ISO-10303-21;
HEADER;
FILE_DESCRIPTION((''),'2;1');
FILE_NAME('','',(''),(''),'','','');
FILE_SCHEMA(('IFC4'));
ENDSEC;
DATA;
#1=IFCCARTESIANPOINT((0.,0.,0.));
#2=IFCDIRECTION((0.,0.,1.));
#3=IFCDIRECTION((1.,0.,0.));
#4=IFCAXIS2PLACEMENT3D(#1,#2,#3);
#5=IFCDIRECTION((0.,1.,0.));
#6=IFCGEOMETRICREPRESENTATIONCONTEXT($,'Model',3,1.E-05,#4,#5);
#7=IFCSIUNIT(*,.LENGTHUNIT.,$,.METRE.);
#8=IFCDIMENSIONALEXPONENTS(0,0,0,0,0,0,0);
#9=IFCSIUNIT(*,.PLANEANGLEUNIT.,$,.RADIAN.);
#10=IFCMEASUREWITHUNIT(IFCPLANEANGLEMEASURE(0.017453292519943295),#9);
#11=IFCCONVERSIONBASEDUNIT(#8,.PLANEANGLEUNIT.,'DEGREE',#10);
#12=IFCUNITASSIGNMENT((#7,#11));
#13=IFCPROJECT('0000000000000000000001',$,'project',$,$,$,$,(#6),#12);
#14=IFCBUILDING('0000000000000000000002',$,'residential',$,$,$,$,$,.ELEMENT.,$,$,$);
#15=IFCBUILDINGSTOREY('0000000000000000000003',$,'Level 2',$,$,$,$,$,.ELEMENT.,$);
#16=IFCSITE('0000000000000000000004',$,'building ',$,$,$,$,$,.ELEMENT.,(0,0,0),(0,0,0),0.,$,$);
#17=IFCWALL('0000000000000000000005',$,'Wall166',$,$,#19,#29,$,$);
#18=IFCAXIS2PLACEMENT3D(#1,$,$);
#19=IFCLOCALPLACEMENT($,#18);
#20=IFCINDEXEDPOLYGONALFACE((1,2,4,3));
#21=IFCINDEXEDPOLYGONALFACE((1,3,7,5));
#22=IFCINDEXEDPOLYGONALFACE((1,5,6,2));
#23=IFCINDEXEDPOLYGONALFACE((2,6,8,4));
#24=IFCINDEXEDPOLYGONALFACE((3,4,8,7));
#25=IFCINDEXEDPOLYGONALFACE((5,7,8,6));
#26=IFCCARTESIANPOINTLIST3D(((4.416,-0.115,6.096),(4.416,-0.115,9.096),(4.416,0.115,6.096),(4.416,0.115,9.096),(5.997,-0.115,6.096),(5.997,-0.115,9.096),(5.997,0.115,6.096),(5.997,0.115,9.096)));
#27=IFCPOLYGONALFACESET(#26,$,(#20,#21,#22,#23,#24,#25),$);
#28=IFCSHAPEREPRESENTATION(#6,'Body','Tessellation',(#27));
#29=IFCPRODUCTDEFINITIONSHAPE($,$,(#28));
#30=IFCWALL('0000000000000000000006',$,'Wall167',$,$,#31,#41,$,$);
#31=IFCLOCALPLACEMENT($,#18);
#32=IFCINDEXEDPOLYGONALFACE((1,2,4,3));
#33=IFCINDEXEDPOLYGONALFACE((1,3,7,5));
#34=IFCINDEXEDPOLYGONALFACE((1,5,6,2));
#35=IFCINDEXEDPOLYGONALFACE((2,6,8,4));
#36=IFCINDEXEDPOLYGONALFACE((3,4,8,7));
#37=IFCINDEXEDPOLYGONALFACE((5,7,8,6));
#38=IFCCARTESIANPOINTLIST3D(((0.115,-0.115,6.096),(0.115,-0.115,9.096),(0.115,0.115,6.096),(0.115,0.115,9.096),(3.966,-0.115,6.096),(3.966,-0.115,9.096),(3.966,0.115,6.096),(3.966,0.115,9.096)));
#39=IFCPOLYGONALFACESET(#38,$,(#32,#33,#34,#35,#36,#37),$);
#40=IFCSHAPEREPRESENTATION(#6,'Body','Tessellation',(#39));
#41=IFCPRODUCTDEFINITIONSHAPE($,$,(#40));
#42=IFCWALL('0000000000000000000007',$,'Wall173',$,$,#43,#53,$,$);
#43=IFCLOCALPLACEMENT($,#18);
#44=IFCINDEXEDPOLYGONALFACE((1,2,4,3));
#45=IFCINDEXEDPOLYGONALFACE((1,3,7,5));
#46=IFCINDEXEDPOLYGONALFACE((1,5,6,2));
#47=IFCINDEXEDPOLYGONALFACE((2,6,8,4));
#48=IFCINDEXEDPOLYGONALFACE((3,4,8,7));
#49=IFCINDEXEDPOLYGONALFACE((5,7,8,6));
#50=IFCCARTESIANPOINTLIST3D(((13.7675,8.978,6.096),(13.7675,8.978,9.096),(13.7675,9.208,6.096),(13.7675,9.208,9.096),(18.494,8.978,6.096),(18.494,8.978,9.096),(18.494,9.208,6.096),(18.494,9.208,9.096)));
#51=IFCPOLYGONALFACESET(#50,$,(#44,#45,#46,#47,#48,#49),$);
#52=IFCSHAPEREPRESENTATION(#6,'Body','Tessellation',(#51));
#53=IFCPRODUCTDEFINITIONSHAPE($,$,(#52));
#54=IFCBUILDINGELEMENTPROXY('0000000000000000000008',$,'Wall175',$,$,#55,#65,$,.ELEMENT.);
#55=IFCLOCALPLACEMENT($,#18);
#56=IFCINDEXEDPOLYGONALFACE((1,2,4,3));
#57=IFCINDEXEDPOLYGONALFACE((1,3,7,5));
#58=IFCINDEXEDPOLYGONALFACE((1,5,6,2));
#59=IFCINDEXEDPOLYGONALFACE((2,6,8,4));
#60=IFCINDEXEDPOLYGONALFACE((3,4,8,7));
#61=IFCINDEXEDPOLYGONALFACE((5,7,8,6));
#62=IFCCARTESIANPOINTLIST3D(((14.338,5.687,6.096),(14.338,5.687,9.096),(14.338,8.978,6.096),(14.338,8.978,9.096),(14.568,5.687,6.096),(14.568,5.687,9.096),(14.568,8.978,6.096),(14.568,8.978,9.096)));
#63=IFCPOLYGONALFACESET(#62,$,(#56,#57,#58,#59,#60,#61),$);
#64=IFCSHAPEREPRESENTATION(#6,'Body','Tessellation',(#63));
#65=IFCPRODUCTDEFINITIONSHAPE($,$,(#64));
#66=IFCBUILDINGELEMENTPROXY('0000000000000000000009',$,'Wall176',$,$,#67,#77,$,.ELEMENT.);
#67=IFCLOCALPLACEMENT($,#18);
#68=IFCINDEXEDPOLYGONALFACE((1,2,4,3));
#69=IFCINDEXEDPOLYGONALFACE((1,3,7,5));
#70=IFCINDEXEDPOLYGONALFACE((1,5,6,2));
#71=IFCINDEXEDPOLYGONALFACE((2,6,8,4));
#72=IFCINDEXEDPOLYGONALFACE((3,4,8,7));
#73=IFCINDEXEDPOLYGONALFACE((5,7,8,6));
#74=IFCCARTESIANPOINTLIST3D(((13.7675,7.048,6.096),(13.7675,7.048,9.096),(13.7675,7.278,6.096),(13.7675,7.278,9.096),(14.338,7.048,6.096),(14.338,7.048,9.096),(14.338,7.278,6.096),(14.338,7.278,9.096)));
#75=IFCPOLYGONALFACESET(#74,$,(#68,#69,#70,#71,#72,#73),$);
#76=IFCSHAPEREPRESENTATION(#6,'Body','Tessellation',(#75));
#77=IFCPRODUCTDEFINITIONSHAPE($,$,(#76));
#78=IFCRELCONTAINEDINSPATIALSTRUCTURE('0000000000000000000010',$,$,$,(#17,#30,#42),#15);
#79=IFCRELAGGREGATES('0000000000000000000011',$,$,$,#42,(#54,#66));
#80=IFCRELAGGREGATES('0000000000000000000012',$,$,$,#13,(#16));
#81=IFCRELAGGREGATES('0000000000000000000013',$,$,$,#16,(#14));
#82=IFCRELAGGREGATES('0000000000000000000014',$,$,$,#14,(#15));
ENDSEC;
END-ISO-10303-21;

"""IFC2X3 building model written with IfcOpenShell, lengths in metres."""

from ifc_helpers import new_model, entity, si_unit, converted_unit, direction, frame, frame_2d, origin_with_axes, place, context, project, spatial, rectangle, extrude, element, aggregate, save


model = new_model("IFC2X3")

# Units and contexts
model_context = context("Model", 3, precision=1e-05, world=origin_with_axes(), true_north=direction((0.0, 1.0, 0.0)))
ifc_project = project(units=[si_unit("LENGTHUNIT", "METRE"), converted_unit("PLANEANGLEUNIT", "DEGREE", entity("IfcPlaneAngleMeasure", 0.017453292519943295), si_unit("PLANEANGLEUNIT", "RADIAN"), dimensions=[0, 0, 0, 0, 0, 0, 0])], contexts=[model_context])

# Site, building, storey
site = spatial("IfcSite", under=ifc_project, Name="building ", CompositionType="ELEMENT", RefLatitude=(0, 0, 0), RefLongitude=(0, 0, 0), RefElevation=0.0)
building = spatial("IfcBuilding", under=site, Name="residential", CompositionType="ELEMENT")
storey = spatial("IfcBuildingStorey", under=building, Name="Level 2", CompositionType="ELEMENT")

# Shared definitions
placement = place(None, origin_with_axes())

# Walls
element("IfcWall", 1, at=placement, inside=storey, Name="Wall166", context=model_context, shape_type="SweptSolid", body=[
    extrude(rectangle(XDim=1.581, YDim=0.23, at=frame_2d((0.0, 0.0), x_axis=(1.0, 0.0, 0.0))), frame((5.2065, 0.0, 6.096), z_axis=(0.0, 0.0, 1.0), x_axis=(1.0, 0.0, 0.0)), (0.0, 0.0, 1.0), 3.0),
])
element("IfcWall", 2, at=placement, inside=storey, Name="Wall167", context=model_context, shape_type="SweptSolid", body=[
    extrude(rectangle(XDim=3.851, YDim=0.23, at=frame_2d((0.0, 0.0), x_axis=(1.0, 0.0, 0.0))), frame((2.0405, 0.0, 6.096), z_axis=(0.0, 0.0, 1.0), x_axis=(1.0, 0.0, 0.0)), (0.0, 0.0, 1.0), 3.0),
])

# Wall
wall_1 = element("IfcWall", 3, at=placement, inside=storey, Name="Wall173", context=model_context, shape_type="SweptSolid", body=[
    extrude(rectangle(XDim=4.7265, YDim=0.23, at=frame_2d((0.0, 0.0), x_axis=(1.0, 0.0, 0.0))), frame((16.1307, 9.093, 6.096), z_axis=(0.0, 0.0, 1.0), x_axis=(1.0, 0.0, 0.0)), (0.0, 0.0, 1.0), 3.0),
])

# Building element proxies
proxy_1 = element("IfcBuildingElementProxy", 4, at=placement, Name="Wall175", CompositionType="ELEMENT", context=model_context, shape_type="SweptSolid", body=[
    extrude(rectangle(XDim=3.291, YDim=0.23, at=frame_2d((0.0, 0.0), x_axis=(0.0, 1.0, 0.0))), frame((14.453, 7.3325, 6.096), z_axis=(0.0, 0.0, 1.0), x_axis=(1.0, 0.0, 0.0)), (0.0, 0.0, 1.0), 3.0),
])
proxy_2 = element("IfcBuildingElementProxy", 5, at=placement, Name="Wall176", CompositionType="ELEMENT", context=model_context, shape_type="SweptSolid", body=[
    extrude(rectangle(XDim=0.5705, YDim=0.23, at=frame_2d((0.0, 0.0), x_axis=(1.0, 0.0, 0.0))), frame((14.0527, 7.163, 6.096), z_axis=(0.0, 0.0, 1.0), x_axis=(1.0, 0.0, 0.0)), (0.0, 0.0, 1.0), 3.0),
])
aggregate(wall_1, [proxy_1, proxy_2])

save(model, "model.ifc")
